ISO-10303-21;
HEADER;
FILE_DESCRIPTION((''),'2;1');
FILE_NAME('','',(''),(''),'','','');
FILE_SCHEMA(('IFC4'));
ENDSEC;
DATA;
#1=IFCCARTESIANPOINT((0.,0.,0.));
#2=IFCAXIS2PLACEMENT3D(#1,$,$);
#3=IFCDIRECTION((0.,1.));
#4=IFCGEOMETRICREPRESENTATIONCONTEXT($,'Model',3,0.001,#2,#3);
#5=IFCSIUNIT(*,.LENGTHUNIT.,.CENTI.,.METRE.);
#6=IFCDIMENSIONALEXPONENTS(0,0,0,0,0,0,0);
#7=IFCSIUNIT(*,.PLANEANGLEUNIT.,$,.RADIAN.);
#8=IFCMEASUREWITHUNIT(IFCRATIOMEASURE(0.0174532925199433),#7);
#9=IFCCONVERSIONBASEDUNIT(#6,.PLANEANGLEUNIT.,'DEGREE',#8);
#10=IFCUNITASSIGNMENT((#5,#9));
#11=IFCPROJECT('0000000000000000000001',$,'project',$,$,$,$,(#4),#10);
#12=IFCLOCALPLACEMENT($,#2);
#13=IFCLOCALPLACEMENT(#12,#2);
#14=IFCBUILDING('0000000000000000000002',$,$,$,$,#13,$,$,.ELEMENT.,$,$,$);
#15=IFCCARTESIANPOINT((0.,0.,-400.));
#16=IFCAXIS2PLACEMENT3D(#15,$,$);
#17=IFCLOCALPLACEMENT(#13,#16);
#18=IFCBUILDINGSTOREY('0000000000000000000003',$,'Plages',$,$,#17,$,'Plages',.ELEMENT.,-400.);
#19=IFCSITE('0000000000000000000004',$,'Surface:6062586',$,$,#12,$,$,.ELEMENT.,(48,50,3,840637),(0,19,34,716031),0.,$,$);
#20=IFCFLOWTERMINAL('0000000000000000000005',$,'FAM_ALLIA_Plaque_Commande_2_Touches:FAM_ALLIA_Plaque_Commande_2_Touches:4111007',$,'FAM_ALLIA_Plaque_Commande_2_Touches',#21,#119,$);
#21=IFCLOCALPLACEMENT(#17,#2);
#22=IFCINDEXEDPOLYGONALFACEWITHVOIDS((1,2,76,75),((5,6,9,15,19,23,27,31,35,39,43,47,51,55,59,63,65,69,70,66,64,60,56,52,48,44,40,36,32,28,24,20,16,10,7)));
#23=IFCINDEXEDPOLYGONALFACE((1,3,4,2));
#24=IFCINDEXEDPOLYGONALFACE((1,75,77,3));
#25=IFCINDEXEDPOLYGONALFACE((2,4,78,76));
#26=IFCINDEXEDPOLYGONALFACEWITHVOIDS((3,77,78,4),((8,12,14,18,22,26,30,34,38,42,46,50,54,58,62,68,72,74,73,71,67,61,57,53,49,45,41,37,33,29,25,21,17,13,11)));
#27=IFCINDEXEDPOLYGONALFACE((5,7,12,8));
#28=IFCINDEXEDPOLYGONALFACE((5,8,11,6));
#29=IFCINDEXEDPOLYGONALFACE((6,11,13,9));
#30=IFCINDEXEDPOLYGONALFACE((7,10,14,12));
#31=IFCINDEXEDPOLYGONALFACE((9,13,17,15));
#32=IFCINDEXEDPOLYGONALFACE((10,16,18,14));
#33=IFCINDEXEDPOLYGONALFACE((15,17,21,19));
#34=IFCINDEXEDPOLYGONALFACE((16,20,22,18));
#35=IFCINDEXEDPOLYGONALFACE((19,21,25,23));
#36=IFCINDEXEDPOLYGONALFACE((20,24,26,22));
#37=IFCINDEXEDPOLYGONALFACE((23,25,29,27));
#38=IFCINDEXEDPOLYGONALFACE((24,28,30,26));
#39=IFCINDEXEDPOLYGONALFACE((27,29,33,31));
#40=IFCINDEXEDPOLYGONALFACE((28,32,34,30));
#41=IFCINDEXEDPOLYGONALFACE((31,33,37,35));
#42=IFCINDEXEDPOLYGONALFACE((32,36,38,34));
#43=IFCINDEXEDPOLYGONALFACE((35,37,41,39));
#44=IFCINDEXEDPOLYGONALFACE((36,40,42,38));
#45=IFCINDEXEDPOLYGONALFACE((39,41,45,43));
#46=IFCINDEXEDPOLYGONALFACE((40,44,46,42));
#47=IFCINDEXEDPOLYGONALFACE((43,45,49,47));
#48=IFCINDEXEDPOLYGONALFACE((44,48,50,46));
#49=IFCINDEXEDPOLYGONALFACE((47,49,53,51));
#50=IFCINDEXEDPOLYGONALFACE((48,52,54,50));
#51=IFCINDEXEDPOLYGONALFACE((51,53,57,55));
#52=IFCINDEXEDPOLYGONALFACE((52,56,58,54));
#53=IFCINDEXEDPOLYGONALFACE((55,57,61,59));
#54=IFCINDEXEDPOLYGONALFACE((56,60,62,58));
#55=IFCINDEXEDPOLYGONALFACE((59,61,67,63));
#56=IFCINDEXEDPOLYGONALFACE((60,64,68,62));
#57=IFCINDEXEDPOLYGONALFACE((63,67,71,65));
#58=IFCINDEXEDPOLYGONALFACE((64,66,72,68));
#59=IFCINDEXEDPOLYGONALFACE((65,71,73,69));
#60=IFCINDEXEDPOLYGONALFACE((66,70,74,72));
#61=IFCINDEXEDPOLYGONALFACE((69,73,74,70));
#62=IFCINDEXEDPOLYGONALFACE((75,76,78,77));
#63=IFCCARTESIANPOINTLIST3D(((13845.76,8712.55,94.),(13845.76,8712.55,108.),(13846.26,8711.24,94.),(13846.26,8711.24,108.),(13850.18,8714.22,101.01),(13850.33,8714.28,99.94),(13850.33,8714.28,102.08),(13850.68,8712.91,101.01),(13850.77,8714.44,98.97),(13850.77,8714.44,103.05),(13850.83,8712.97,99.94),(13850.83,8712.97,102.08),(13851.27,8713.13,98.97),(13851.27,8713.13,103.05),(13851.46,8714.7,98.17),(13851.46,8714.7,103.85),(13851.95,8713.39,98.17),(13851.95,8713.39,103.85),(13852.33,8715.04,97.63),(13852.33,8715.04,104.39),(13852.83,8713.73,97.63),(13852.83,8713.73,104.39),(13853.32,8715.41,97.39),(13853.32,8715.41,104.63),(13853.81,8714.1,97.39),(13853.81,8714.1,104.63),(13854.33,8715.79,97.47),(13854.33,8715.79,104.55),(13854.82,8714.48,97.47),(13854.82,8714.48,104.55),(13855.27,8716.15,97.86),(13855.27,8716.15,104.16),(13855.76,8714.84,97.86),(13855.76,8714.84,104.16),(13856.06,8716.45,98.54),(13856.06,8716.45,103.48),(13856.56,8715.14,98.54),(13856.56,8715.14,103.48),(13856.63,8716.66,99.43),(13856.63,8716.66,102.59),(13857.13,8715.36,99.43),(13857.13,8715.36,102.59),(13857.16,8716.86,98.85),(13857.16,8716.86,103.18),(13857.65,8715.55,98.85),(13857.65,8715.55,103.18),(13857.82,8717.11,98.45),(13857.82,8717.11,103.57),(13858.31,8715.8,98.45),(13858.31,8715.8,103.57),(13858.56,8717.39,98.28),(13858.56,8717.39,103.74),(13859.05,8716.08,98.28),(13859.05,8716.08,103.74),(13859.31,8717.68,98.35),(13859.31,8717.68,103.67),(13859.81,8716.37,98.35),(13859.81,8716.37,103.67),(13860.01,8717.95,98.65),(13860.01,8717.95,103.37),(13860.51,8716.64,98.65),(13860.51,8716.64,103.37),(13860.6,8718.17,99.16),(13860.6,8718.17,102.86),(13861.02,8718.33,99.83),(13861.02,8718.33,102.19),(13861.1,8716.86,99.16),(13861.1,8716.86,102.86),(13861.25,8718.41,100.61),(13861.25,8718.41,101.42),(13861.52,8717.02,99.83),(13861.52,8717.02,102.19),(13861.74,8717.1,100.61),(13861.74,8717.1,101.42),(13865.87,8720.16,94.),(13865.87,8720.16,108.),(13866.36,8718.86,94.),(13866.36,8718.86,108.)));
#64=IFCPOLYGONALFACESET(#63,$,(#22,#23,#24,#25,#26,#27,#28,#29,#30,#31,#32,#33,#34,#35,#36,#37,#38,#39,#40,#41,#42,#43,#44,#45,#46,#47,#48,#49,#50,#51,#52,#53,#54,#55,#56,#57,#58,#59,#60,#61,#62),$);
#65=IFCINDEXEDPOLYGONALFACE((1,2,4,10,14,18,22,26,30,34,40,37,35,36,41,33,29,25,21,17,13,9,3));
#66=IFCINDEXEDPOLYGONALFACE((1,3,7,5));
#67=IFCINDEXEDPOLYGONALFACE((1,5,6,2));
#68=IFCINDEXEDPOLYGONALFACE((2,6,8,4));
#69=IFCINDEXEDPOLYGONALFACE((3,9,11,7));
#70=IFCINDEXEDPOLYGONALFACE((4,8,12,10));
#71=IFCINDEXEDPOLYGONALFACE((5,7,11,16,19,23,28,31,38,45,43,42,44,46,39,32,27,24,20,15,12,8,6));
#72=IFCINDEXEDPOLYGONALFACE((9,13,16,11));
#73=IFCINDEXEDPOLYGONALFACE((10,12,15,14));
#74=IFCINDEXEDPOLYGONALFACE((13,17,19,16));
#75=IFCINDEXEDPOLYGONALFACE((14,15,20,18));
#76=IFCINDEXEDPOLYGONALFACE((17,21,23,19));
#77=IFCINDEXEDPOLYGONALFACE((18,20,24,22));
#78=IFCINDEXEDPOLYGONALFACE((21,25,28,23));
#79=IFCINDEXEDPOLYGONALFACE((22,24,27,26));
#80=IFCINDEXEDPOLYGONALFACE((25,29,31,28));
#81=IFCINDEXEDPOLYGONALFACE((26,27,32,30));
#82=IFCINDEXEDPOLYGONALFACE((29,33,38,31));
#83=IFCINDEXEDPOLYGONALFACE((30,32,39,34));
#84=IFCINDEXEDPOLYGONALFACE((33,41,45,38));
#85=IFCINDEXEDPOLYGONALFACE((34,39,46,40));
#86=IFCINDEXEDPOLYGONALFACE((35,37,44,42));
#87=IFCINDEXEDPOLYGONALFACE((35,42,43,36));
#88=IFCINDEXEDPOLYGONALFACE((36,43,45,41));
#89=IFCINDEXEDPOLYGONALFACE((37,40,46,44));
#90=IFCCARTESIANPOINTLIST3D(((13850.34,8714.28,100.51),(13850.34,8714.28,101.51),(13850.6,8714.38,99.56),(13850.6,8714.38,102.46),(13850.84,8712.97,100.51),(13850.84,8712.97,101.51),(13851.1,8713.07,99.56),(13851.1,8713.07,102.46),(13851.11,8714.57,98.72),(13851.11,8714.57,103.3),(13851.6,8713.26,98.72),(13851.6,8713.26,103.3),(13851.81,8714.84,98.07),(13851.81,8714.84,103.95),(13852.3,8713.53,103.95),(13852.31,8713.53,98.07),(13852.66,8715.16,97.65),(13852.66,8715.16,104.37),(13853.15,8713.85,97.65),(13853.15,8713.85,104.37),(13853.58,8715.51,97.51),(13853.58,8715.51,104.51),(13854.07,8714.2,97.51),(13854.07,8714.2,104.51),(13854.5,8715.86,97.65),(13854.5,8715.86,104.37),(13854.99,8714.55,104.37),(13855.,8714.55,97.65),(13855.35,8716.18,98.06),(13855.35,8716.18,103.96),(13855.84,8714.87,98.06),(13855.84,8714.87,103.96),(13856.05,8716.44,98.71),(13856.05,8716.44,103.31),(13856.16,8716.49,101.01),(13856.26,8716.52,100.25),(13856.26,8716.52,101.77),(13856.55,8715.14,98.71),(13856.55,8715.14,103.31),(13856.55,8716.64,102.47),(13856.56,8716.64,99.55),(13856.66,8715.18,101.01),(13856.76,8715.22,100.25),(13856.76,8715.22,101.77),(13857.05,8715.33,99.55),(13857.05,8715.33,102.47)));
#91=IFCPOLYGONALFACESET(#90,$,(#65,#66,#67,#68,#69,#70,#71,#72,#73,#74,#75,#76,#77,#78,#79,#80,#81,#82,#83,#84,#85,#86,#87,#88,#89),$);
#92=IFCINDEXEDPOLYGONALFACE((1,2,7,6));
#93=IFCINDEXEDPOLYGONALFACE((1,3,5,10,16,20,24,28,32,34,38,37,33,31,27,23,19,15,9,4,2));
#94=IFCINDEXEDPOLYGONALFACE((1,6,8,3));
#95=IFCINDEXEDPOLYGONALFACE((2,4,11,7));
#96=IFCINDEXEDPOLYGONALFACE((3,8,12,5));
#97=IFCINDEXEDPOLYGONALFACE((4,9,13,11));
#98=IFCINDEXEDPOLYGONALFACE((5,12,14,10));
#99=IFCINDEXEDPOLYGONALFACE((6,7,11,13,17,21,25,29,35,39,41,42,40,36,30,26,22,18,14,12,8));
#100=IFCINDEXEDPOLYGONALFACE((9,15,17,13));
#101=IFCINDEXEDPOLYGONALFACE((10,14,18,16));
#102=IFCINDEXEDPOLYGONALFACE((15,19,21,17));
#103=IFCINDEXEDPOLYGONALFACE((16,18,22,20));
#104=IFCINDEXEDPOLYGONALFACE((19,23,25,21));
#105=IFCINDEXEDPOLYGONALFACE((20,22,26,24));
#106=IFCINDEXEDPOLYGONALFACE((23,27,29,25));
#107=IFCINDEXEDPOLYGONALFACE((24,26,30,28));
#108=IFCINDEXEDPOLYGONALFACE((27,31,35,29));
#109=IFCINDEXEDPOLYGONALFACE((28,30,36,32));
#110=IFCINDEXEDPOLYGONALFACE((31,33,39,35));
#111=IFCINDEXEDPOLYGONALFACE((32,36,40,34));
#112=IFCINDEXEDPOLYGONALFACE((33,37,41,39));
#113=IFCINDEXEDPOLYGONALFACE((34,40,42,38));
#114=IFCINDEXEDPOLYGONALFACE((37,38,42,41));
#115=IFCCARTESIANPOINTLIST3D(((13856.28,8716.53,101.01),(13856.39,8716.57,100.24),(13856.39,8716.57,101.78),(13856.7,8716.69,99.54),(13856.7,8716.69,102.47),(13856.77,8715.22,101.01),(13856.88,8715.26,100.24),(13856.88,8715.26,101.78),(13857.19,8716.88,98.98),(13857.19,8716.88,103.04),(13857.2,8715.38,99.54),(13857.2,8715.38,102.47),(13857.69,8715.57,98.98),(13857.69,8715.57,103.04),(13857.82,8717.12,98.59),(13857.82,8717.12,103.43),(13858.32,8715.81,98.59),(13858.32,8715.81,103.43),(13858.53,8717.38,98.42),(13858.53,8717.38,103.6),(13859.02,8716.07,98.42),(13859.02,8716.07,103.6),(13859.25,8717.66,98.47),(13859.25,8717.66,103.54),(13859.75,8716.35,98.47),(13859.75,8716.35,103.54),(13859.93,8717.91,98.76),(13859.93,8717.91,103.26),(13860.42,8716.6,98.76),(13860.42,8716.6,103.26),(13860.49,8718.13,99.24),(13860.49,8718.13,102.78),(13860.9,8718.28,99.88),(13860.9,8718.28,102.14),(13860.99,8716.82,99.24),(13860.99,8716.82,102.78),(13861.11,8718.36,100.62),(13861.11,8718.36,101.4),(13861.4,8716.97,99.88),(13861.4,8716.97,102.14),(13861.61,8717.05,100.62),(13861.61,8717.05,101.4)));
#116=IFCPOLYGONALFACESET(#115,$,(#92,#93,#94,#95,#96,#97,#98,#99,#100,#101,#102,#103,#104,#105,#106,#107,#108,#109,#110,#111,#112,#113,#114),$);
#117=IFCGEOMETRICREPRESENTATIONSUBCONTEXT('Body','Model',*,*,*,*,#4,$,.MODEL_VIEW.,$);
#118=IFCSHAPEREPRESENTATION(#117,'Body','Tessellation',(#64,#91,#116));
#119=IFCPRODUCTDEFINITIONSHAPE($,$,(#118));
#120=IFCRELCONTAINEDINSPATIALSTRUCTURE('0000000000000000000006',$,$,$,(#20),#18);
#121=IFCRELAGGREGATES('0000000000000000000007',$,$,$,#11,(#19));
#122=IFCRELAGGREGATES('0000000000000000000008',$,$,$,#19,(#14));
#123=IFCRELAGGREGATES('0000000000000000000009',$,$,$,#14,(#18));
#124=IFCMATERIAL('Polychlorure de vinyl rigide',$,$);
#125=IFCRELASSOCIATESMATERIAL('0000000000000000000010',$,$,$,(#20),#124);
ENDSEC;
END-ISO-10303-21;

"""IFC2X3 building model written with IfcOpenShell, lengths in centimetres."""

from ifc_helpers import new_model, entity, si_unit, converted_unit, direction, frame, frame_2d, origin, place, context, subcontext, project, spatial, polyline, circle_curve, parameter, trimmed, segment, composite_curve, circle, outline, extrude, source, transform, mapped, material, element, save


model = new_model("IFC2X3")

# Units and contexts
model_context = context("Model", 3, precision=0.001, world=origin(), true_north=direction((0.0, 1.0)))
body_context = subcontext(model_context, "Body", "Model", "MODEL_VIEW")
ifc_project = project(units=[si_unit("LENGTHUNIT", "METRE", prefix="CENTI"), converted_unit("PLANEANGLEUNIT", "DEGREE", entity("IfcRatioMeasure", 0.0174532925199433), si_unit("PLANEANGLEUNIT", "RADIAN"), dimensions=[0, 0, 0, 0, 0, 0, 0])], contexts=[model_context])

# Site, building, storey
site_placement = place(None, origin())
site = spatial("IfcSite", under=ifc_project, at=site_placement, Name="Surface:6062586", CompositionType="ELEMENT", RefLatitude=(48, 50, 3, 840637), RefLongitude=(0, 19, 34, 716031), RefElevation=0.0)
building_placement = place(site_placement, origin())
building = spatial("IfcBuilding", under=site, at=building_placement, CompositionType="ELEMENT")
storey_placement = place(building_placement, frame((0.0, 0.0, -400.0)))
storey = spatial("IfcBuildingStorey", under=building, at=storey_placement, Name="Plages", LongName="Plages", CompositionType="ELEMENT", Elevation=-400.0)

# Flow terminal
ifc_material_1 = material(Name="Polychlorure de vinyl rigide")
shared_shape_1 = source(origin(), body_context, "Body", "SweptSolid", [
    extrude(outline(polyline([(-10.75, -7.0), (10.75, -7.0), (10.75, 7.0), (-10.75, 7.0), (-10.75, -7.0)]), holes=[composite_curve([segment(trimmed(circle_curve(frame_2d((-3.1, 0.01), x_axis=(-1.0, 0.0)), 2.73), [parameter(215.328783)], [parameter(144.671217)], True, "PARAMETER"), False, "CONTINUOUS"), segment(trimmed(circle_curve(frame_2d((2.39, 0.01), x_axis=(-1.0, 0.0)), 3.63), [parameter(25.817037)], [parameter(334.182963)], True, "PARAMETER"), False, "CONTINUOUS")], self_intersect=False)]), frame((10.75, 0.0, 7.0), z_axis=(0.0, 1.0, 0.0), x_axis=(-1.0, 0.0, 0.0)), (0.0, 0.0, 1.0), 1.4),
    extrude(outline(composite_curve([segment(trimmed(circle_curve(frame_2d((-3.18, 0.0), x_axis=(1.0, 0.0)), 3.5), [parameter(24.630749)], [parameter(335.341392)], True, "PARAMETER"), True, "CONTINUOUS"), segment(trimmed(circle_curve(frame_2d((2.31, 0.0), x_axis=(1.0, 0.0)), 2.73), [parameter(147.719336)], [parameter(212.252805)], True, "PARAMETER"), False, "CONTINUOUS")], self_intersect=False)), frame((11.54, 0.0, 7.01), z_axis=(0.0, 1.0, 0.0), x_axis=(1.0, 0.0, 0.0)), (0.0, 0.0, 1.0), 1.4),
    extrude(circle(Radius=2.6, at=frame_2d((0.0, 0.0), x_axis=(1.0, 0.0))), frame((13.85, 0.0, 7.01), z_axis=(0.0, 1.0, 0.0), x_axis=(-1.0, 0.0, 0.0)), (0.0, 0.0, 1.0), 1.4),
])
for number, where, z_axis, x_axis, name in (
    (1, (13846.26, 8711.24, 94.0), (0.0, 0.0, 1.0), (0.935103, 0.354376, 0.0), "FAM_ALLIA_Plaque_Commande_2_Touches:FAM_ALLIA_Plaque_Commande_2_Touches:4111007"),
):
    element("IfcFlowTerminal", number, at=place(storey_placement, frame(where, z_axis=z_axis, x_axis=x_axis)), inside=storey, material=ifc_material_1, Name=name, ObjectType="FAM_ALLIA_Plaque_Commande_2_Touches", context=body_context, shape_type="MappedRepresentation", body=[
        mapped(shared_shape_1, transform((0.0, 0.0, 0.0), scale=1.0)),
    ])

save(model, "model.ifc")
